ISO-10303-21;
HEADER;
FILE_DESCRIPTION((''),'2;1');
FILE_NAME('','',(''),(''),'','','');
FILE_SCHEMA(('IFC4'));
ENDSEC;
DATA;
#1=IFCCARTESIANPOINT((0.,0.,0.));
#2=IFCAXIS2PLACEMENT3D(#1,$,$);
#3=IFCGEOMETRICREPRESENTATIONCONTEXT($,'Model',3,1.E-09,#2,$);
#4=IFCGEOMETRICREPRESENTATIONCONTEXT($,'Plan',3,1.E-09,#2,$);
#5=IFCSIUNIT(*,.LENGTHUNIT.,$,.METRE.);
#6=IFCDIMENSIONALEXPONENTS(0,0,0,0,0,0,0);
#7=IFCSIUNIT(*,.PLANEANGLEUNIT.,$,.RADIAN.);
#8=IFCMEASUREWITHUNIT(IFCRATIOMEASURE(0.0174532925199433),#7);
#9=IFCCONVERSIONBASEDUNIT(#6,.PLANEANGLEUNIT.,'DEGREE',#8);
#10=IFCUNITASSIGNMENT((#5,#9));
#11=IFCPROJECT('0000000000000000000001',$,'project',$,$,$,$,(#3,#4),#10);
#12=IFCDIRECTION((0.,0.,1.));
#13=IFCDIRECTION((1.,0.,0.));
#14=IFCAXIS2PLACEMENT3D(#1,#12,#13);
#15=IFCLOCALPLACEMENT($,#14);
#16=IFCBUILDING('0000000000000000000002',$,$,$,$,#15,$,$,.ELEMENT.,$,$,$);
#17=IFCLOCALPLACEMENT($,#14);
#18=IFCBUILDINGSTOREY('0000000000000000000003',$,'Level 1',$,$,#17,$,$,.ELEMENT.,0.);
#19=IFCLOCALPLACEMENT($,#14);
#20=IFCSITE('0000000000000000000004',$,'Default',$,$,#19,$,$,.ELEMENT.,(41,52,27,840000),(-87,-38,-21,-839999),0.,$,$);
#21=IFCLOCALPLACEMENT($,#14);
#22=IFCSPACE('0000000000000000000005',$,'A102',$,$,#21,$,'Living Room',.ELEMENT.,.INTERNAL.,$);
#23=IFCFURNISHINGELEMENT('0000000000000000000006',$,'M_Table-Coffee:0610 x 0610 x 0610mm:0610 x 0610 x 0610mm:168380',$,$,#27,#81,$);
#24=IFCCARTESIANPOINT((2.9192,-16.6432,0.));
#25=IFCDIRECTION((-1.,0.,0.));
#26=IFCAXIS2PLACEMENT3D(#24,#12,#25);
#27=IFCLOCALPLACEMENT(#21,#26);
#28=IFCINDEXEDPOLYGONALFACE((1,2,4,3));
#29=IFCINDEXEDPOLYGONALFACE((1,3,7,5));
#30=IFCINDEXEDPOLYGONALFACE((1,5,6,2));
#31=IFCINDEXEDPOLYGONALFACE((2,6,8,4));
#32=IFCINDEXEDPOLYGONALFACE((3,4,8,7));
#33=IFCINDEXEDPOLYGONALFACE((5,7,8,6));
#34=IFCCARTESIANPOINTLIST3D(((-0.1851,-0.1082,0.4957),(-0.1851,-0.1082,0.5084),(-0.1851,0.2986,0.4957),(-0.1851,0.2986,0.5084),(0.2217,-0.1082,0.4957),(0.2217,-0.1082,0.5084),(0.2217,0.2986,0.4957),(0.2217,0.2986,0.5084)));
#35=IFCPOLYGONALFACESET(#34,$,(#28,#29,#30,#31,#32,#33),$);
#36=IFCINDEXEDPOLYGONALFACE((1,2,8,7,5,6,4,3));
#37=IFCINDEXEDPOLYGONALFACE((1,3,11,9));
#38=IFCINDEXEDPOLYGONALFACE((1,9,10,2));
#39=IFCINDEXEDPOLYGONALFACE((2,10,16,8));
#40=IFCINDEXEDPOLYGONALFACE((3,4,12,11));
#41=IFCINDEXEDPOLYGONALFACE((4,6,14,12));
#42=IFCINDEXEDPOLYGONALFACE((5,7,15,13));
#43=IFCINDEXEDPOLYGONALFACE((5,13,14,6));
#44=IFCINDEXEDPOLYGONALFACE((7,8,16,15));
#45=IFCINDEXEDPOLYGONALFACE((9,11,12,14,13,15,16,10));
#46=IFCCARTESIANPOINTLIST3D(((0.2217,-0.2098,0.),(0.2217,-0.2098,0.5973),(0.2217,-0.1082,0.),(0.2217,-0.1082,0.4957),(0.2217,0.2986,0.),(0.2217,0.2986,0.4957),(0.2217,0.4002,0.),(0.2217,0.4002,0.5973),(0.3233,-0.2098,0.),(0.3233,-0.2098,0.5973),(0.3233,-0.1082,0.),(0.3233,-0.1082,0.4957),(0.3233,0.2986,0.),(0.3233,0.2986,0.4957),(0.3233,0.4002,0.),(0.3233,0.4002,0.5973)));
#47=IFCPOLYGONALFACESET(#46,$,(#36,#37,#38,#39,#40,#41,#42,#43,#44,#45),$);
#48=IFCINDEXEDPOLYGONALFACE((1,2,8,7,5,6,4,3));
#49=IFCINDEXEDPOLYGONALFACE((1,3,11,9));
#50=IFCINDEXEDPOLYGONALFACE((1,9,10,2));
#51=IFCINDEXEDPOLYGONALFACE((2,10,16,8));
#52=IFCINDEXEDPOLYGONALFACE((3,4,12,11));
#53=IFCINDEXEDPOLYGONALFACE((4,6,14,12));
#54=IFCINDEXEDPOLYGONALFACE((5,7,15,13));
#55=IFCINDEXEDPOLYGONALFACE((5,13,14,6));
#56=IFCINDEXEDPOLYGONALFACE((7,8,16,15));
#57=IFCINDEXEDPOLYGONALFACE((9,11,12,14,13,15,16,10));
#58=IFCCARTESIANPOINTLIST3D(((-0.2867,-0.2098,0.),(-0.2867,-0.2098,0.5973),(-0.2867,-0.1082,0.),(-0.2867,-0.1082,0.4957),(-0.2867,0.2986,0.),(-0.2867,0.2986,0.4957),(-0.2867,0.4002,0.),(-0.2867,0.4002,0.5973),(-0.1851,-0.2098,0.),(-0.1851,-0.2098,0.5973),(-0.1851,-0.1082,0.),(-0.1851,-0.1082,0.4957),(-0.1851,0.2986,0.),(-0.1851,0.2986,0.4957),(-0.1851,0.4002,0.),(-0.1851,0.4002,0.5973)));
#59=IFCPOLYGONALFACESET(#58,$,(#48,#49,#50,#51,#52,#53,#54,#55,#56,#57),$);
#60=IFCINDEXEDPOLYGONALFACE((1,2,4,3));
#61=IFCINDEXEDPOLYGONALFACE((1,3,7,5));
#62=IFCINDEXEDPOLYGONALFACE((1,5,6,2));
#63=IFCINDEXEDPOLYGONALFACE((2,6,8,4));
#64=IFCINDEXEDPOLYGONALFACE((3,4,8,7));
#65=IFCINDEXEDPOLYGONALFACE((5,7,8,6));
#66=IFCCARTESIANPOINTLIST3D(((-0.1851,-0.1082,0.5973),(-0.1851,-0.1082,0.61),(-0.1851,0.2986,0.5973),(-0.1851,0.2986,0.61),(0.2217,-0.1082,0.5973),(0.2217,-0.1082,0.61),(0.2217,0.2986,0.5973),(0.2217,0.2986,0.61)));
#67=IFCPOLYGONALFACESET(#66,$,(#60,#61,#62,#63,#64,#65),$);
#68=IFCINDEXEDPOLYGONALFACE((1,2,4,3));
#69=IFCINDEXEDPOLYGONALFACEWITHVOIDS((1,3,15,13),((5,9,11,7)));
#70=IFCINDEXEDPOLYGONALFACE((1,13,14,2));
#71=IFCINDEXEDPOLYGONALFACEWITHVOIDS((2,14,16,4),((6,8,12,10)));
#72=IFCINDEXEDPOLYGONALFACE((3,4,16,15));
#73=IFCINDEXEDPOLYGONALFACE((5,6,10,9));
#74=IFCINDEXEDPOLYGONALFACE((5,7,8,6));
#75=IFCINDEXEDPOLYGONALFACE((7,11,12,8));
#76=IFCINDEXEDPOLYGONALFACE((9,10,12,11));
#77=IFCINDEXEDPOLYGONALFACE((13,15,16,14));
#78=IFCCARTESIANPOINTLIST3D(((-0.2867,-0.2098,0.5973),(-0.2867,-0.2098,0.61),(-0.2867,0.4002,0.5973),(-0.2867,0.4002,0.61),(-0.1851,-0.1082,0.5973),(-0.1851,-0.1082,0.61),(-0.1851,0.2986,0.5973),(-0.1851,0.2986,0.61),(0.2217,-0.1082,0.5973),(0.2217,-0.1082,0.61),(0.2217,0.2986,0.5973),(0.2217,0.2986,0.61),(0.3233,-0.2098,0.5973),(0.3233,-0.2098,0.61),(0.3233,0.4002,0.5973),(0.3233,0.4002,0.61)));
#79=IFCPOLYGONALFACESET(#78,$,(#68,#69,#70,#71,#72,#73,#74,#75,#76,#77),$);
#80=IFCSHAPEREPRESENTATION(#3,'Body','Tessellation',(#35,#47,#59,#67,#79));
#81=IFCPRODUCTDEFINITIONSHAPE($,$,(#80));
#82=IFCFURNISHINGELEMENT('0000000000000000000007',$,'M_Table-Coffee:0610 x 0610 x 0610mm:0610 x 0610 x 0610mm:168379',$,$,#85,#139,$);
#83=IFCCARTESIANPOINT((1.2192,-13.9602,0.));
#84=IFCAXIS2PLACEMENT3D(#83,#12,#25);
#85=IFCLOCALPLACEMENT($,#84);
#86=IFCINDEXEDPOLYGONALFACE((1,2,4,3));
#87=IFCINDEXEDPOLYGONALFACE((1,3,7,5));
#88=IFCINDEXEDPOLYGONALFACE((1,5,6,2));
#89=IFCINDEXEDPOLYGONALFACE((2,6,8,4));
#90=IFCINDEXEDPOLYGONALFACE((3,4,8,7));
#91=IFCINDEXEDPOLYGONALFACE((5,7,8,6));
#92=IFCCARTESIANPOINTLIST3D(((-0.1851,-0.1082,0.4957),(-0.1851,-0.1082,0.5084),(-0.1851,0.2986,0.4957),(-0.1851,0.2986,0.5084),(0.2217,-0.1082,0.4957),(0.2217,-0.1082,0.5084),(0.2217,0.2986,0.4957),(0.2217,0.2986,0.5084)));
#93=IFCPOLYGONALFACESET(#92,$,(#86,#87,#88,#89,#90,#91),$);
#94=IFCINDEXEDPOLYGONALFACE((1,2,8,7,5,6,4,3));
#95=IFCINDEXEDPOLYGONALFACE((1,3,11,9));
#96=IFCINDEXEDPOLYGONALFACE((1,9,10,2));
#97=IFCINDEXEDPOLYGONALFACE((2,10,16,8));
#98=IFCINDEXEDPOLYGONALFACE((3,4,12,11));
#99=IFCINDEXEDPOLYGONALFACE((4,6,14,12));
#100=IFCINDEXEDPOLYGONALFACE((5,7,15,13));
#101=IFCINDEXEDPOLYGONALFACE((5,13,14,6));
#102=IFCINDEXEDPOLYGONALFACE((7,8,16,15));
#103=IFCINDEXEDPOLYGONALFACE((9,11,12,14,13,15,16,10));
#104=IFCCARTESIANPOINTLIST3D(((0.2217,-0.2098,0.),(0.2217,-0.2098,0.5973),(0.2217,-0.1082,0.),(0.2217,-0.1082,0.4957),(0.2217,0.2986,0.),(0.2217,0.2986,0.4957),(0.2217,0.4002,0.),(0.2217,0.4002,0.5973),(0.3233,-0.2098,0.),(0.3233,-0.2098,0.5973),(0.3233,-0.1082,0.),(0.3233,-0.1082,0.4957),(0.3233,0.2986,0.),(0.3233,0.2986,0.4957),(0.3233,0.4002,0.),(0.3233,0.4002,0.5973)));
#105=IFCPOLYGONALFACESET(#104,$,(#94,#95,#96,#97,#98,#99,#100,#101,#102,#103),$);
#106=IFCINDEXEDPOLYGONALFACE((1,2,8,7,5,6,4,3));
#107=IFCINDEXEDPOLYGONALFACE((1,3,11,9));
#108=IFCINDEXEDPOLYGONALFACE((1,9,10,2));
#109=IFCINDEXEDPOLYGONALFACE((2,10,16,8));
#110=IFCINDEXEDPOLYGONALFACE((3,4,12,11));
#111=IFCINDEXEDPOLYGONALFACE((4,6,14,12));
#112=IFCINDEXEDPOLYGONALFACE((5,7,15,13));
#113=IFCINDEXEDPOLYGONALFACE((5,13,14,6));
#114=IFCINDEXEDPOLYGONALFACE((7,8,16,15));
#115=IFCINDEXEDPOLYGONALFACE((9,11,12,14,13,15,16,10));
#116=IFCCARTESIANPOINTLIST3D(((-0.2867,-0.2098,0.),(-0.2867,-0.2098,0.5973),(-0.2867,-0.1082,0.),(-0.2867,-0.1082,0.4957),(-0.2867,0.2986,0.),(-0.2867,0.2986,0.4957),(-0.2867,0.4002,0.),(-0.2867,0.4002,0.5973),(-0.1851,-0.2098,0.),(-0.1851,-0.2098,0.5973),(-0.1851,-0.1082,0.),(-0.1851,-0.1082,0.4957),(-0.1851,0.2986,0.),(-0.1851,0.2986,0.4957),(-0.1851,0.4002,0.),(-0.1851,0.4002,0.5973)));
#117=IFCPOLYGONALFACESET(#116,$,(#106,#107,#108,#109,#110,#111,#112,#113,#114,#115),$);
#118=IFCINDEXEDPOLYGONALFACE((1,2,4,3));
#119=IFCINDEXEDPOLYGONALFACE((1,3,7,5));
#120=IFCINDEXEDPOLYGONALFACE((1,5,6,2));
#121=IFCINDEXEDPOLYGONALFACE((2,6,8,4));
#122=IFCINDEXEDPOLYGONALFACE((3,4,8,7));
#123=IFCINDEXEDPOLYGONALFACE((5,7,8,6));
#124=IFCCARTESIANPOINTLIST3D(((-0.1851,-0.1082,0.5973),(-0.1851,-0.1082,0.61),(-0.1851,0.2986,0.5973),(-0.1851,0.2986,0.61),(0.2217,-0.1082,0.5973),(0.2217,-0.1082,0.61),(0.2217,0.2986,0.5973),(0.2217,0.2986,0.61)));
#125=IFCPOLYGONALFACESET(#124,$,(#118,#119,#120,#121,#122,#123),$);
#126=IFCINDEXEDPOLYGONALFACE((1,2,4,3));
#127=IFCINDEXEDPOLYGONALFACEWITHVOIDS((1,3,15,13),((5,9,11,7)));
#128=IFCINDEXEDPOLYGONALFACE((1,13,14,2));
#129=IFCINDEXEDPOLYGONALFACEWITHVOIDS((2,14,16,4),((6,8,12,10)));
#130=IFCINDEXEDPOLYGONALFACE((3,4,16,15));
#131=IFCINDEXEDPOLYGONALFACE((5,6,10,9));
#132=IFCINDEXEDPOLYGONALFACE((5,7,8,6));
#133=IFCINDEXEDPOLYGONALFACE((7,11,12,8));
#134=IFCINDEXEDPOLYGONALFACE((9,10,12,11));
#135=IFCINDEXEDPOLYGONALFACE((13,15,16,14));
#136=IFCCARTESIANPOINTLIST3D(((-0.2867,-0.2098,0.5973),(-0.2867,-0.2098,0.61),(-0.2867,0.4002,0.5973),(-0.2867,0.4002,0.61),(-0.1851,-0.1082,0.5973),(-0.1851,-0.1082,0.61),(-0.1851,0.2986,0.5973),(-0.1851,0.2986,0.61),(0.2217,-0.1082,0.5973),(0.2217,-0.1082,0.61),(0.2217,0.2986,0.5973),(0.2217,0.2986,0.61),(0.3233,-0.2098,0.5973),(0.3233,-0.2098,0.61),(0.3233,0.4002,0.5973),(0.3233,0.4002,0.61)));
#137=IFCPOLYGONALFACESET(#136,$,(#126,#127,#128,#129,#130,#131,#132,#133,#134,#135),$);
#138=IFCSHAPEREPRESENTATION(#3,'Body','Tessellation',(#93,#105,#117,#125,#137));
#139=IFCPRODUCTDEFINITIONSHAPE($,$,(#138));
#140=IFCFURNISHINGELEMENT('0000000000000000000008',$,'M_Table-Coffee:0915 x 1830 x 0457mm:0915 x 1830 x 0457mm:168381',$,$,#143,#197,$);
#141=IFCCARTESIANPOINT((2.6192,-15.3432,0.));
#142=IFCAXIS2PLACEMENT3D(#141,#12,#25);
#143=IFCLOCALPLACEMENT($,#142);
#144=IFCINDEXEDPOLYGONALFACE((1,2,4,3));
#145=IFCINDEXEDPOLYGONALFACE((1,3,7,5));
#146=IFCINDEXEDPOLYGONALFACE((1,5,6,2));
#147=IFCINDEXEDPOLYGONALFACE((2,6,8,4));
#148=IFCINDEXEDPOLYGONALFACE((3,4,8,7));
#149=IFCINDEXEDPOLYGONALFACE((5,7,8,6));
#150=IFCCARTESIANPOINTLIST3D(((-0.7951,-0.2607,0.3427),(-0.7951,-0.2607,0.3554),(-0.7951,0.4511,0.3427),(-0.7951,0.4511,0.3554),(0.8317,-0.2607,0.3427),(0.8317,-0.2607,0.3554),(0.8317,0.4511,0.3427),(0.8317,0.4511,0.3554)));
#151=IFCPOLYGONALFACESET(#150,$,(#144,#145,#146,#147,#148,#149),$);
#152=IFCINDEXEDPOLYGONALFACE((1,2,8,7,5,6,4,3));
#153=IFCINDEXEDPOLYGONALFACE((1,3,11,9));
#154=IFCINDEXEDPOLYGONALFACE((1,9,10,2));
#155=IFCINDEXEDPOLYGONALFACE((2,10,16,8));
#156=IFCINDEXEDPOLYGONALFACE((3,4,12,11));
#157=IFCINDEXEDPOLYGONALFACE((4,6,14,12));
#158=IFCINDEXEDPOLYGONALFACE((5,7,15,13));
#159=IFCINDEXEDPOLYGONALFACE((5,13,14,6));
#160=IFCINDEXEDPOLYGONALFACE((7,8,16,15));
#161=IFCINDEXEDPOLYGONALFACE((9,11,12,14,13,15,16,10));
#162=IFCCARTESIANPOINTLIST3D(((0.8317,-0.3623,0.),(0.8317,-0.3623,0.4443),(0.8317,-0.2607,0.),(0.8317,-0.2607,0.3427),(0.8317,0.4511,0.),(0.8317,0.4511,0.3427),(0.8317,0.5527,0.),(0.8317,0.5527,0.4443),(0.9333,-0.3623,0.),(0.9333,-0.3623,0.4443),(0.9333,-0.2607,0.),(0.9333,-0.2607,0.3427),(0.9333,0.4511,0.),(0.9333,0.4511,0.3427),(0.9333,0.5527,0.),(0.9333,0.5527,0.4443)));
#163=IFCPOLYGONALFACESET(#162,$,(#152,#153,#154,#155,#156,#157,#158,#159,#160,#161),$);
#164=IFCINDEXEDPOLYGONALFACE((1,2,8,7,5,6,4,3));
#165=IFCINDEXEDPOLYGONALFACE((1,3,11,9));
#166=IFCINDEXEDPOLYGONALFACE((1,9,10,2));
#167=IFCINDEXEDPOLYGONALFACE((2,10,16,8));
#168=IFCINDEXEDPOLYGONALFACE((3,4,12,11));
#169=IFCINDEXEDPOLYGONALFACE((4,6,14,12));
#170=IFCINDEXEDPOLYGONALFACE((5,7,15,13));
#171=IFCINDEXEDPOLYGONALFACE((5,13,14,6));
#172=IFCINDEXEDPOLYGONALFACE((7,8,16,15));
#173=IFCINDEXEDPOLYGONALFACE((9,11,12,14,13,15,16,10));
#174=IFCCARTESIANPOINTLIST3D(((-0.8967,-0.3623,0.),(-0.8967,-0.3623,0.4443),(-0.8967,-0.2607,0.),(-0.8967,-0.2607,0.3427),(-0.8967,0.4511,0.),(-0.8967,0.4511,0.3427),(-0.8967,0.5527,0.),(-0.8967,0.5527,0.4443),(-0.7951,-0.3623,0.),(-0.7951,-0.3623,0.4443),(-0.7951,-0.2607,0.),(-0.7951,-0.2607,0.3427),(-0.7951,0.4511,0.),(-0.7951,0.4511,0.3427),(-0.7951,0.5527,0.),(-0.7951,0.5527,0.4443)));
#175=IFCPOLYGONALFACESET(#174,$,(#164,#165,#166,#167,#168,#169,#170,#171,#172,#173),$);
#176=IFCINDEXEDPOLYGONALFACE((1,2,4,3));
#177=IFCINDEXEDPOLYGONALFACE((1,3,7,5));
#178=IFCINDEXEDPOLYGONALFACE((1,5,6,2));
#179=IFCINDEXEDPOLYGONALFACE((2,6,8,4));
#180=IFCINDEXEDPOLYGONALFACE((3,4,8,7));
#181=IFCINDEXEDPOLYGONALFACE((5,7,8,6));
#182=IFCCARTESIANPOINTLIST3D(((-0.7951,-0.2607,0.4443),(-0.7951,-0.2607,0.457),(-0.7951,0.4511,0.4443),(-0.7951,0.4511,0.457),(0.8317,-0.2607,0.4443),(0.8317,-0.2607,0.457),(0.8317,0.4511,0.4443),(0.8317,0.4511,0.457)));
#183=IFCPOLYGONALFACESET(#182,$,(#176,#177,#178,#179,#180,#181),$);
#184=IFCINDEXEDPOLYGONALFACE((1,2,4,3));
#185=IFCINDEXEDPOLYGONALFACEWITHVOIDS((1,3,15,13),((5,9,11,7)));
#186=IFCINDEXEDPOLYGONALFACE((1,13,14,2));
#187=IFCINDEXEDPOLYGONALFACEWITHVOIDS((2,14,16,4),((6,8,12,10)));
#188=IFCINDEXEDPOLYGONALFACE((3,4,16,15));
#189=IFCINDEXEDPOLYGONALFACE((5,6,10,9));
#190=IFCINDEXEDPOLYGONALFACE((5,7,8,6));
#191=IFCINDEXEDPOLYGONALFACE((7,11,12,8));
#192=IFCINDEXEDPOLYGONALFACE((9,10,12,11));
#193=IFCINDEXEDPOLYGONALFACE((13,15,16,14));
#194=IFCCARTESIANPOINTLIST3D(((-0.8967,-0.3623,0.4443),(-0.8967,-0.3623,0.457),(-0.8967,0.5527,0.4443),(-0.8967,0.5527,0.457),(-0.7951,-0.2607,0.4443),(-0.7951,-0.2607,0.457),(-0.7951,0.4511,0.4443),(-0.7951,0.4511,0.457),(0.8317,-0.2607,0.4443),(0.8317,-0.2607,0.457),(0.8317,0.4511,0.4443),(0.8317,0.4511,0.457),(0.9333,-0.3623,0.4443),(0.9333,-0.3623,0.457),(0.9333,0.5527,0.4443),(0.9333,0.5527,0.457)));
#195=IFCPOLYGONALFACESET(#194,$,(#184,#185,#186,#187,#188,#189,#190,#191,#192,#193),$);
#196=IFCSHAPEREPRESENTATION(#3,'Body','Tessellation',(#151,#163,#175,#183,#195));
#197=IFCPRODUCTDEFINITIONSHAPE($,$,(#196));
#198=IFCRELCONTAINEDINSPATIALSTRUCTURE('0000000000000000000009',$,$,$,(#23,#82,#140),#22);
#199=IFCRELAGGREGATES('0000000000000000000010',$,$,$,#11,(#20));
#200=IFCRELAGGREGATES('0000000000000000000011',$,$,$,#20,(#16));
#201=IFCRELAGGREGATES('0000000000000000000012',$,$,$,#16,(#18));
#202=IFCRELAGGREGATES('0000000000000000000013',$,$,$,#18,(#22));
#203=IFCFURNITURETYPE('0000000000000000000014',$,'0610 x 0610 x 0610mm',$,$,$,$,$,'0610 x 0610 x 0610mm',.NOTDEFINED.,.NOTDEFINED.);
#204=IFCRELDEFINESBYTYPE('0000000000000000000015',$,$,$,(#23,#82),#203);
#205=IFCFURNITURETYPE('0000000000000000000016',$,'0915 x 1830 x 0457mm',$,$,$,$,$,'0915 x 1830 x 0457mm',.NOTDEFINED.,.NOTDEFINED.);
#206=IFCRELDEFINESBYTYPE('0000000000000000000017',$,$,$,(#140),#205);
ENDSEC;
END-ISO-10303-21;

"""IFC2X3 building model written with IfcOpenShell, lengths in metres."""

from ifc_helpers import new_model, entity, si_unit, converted_unit, frame, origin, origin_with_axes, origin_2d_with_axis, place, context, project, spatial, polyline, rectangle, outline, extrude, source, transform, mapped, type_object, type_shapes, element, save


model = new_model("IFC2X3")

# Units and contexts
model_context = context("Model", 3, precision=1e-09, world=origin())
plan_context = context("Plan", 3, precision=1e-09, world=origin())
ifc_project = project(units=[si_unit("LENGTHUNIT", "METRE"), converted_unit("PLANEANGLEUNIT", "DEGREE", entity("IfcRatioMeasure", 0.0174532925199433), si_unit("PLANEANGLEUNIT", "RADIAN"), dimensions=[0, 0, 0, 0, 0, 0, 0])], contexts=[model_context, plan_context])

# Site, building, storey, space
site_placement = place(None, origin_with_axes())
site = spatial("IfcSite", under=ifc_project, at=site_placement, Name="Default", CompositionType="ELEMENT", RefLatitude=(41, 52, 27, 840000), RefLongitude=(-87, -38, -21, -839999), RefElevation=0.0)
building_placement = place(None, origin_with_axes())
building = spatial("IfcBuilding", under=site, at=building_placement, CompositionType="ELEMENT")
storey_placement = place(None, origin_with_axes())
storey = spatial("IfcBuildingStorey", under=building, at=storey_placement, Name="Level 1", CompositionType="ELEMENT", Elevation=0.0)
space_placement = place(None, origin_with_axes())
space = spatial("IfcSpace", under=storey, at=space_placement, Name="A102", LongName="Living Room", CompositionType="ELEMENT", InteriorOrExteriorSpace="INTERNAL")

# Furnishing elements
furniture_type_1 = type_object("IfcFurnitureType", Name="0610 x 0610 x 0610mm", ElementType="0610 x 0610 x 0610mm", AssemblyPlace="NOTDEFINED")
shared_shape_1 = source(origin(), model_context, "Body", "SweptSolid", [
    extrude(rectangle(XDim=0.4068, YDim=0.4068, at=origin_2d_with_axis()), frame((0.0183, 0.0952, 0.4957), z_axis=(0.0, 0.0, 1.0), x_axis=(-1.0, 0.0, 0.0)), (0.0, 0.0, 1.0), 0.0127),
    extrude(outline(polyline([(-0.2732, -0.305), (0.324, -0.305), (0.324, 0.305), (-0.2732, 0.305), (-0.2732, 0.2034), (0.2225, 0.2034), (0.2225, -0.2034), (-0.2732, -0.2034), (-0.2732, -0.305)])), frame((0.2217, 0.0952, 0.2732), z_axis=(1.0, 0.0, 0.0), x_axis=(0.0, 0.0, 1.0)), (0.0, 0.0, 1.0), 0.1016),
    extrude(outline(polyline([(-0.305, -0.3241), (0.305, -0.3241), (0.305, 0.2733), (0.2034, 0.2733), (0.2034, -0.2224), (-0.2034, -0.2224), (-0.2034, 0.2733), (-0.305, 0.2733), (-0.305, -0.3241)])), frame((-0.2867, 0.0952, 0.2733), z_axis=(1.0, 0.0, 0.0), x_axis=(0.0, -1.0, 0.0)), (0.0, 0.0, 1.0), 0.1016),
    extrude(rectangle(XDim=0.4068, YDim=0.4068, at=origin_2d_with_axis()), frame((0.0183, 0.0952, 0.5973), z_axis=(0.0, 0.0, 1.0), x_axis=(-1.0, 0.0, 0.0)), (0.0, 0.0, 1.0), 0.0127),
    extrude(outline(polyline([(-0.305, -0.305), (0.305, -0.305), (0.305, 0.305), (-0.305, 0.305), (-0.305, -0.305)]), holes=[polyline([(-0.2034, -0.2034), (-0.2034, 0.2034), (0.2034, 0.2034), (0.2034, -0.2034), (-0.2034, -0.2034)])]), frame((0.0183, 0.0952, 0.5973), z_axis=(0.0, 0.0, 1.0), x_axis=(-1.0, 0.0, 0.0)), (0.0, 0.0, 1.0), 0.0127),
])
type_shapes(furniture_type_1, [shared_shape_1])
furnishing_1_placement = place(space_placement, frame((2.9192, -16.6432, 0.0), z_axis=(0.0, 0.0, 1.0), x_axis=(-1.0, 0.0, 0.0)))
element("IfcFurnishingElement", 1, at=furnishing_1_placement, inside=space, type_object=furniture_type_1, Name="M_Table-Coffee:0610 x 0610 x 0610mm:0610 x 0610 x 0610mm:168380", context=model_context, shape_type="MappedRepresentation", body=[
    mapped(shared_shape_1, transform((0.0, 0.0, 0.0), scale=1.0)),
])
furnishing_2_placement = place(None, frame((1.2192, -13.9602, 0.0), z_axis=(0.0, 0.0, 1.0), x_axis=(-1.0, 0.0, 0.0)))
element("IfcFurnishingElement", 2, at=furnishing_2_placement, inside=space, type_object=furniture_type_1, Name="M_Table-Coffee:0610 x 0610 x 0610mm:0610 x 0610 x 0610mm:168379", context=model_context, shape_type="MappedRepresentation", body=[
    mapped(shared_shape_1, transform((0.0, 0.0, 0.0), scale=1.0)),
])
furniture_type_2 = type_object("IfcFurnitureType", Name="0915 x 1830 x 0457mm", ElementType="0915 x 1830 x 0457mm", AssemblyPlace="NOTDEFINED")
shared_shape_2 = source(origin(), model_context, "Body", "SweptSolid", [
    extrude(rectangle(XDim=1.6268, YDim=0.7118, at=origin_2d_with_axis()), frame((0.0183, 0.0952, 0.3427), z_axis=(0.0, 0.0, 1.0), x_axis=(-1.0, 0.0, 0.0)), (0.0, 0.0, 1.0), 0.0127),
    extrude(outline(polyline([(-0.1967, -0.4575), (0.2475, -0.4575), (0.2475, 0.4575), (-0.1967, 0.4575), (-0.1967, 0.3559), (0.146, 0.3559), (0.146, -0.3559), (-0.1967, -0.3559), (-0.1967, -0.4575)])), frame((0.8317, 0.0952, 0.1967), z_axis=(1.0, 0.0, 0.0), x_axis=(0.0, 0.0, 1.0)), (0.0, 0.0, 1.0), 0.1016),
    extrude(outline(polyline([(-0.4575, -0.2476), (0.4575, -0.2476), (0.4575, 0.1968), (0.3559, 0.1968), (0.3559, -0.1459), (-0.3559, -0.1459), (-0.3559, 0.1968), (-0.4575, 0.1968), (-0.4575, -0.2476)])), frame((-0.8967, 0.0952, 0.1968), z_axis=(1.0, 0.0, 0.0), x_axis=(0.0, -1.0, 0.0)), (0.0, 0.0, 1.0), 0.1016),
    extrude(rectangle(XDim=1.6268, YDim=0.7118, at=origin_2d_with_axis()), frame((0.0183, 0.0952, 0.4443), z_axis=(0.0, 0.0, 1.0), x_axis=(-1.0, 0.0, 0.0)), (0.0, 0.0, 1.0), 0.0127),
    extrude(outline(polyline([(-0.915, -0.4575), (0.915, -0.4575), (0.915, 0.4575), (-0.915, 0.4575), (-0.915, -0.4575)]), holes=[polyline([(-0.8134, -0.3559), (-0.8134, 0.3559), (0.8134, 0.3559), (0.8134, -0.3559), (-0.8134, -0.3559)])]), frame((0.0183, 0.0952, 0.4443), z_axis=(0.0, 0.0, 1.0), x_axis=(-1.0, 0.0, 0.0)), (0.0, 0.0, 1.0), 0.0127),
])
type_shapes(furniture_type_2, [shared_shape_2])
furnishing_3_placement = place(None, frame((2.6192, -15.3432, 0.0), z_axis=(0.0, 0.0, 1.0), x_axis=(-1.0, 0.0, 0.0)))
element("IfcFurnishingElement", 3, at=furnishing_3_placement, inside=space, type_object=furniture_type_2, Name="M_Table-Coffee:0915 x 1830 x 0457mm:0915 x 1830 x 0457mm:168381", context=model_context, shape_type="MappedRepresentation", body=[
    mapped(shared_shape_2, transform((0.0, 0.0, 0.0), scale=1.0)),
])

save(model, "model.ifc")
